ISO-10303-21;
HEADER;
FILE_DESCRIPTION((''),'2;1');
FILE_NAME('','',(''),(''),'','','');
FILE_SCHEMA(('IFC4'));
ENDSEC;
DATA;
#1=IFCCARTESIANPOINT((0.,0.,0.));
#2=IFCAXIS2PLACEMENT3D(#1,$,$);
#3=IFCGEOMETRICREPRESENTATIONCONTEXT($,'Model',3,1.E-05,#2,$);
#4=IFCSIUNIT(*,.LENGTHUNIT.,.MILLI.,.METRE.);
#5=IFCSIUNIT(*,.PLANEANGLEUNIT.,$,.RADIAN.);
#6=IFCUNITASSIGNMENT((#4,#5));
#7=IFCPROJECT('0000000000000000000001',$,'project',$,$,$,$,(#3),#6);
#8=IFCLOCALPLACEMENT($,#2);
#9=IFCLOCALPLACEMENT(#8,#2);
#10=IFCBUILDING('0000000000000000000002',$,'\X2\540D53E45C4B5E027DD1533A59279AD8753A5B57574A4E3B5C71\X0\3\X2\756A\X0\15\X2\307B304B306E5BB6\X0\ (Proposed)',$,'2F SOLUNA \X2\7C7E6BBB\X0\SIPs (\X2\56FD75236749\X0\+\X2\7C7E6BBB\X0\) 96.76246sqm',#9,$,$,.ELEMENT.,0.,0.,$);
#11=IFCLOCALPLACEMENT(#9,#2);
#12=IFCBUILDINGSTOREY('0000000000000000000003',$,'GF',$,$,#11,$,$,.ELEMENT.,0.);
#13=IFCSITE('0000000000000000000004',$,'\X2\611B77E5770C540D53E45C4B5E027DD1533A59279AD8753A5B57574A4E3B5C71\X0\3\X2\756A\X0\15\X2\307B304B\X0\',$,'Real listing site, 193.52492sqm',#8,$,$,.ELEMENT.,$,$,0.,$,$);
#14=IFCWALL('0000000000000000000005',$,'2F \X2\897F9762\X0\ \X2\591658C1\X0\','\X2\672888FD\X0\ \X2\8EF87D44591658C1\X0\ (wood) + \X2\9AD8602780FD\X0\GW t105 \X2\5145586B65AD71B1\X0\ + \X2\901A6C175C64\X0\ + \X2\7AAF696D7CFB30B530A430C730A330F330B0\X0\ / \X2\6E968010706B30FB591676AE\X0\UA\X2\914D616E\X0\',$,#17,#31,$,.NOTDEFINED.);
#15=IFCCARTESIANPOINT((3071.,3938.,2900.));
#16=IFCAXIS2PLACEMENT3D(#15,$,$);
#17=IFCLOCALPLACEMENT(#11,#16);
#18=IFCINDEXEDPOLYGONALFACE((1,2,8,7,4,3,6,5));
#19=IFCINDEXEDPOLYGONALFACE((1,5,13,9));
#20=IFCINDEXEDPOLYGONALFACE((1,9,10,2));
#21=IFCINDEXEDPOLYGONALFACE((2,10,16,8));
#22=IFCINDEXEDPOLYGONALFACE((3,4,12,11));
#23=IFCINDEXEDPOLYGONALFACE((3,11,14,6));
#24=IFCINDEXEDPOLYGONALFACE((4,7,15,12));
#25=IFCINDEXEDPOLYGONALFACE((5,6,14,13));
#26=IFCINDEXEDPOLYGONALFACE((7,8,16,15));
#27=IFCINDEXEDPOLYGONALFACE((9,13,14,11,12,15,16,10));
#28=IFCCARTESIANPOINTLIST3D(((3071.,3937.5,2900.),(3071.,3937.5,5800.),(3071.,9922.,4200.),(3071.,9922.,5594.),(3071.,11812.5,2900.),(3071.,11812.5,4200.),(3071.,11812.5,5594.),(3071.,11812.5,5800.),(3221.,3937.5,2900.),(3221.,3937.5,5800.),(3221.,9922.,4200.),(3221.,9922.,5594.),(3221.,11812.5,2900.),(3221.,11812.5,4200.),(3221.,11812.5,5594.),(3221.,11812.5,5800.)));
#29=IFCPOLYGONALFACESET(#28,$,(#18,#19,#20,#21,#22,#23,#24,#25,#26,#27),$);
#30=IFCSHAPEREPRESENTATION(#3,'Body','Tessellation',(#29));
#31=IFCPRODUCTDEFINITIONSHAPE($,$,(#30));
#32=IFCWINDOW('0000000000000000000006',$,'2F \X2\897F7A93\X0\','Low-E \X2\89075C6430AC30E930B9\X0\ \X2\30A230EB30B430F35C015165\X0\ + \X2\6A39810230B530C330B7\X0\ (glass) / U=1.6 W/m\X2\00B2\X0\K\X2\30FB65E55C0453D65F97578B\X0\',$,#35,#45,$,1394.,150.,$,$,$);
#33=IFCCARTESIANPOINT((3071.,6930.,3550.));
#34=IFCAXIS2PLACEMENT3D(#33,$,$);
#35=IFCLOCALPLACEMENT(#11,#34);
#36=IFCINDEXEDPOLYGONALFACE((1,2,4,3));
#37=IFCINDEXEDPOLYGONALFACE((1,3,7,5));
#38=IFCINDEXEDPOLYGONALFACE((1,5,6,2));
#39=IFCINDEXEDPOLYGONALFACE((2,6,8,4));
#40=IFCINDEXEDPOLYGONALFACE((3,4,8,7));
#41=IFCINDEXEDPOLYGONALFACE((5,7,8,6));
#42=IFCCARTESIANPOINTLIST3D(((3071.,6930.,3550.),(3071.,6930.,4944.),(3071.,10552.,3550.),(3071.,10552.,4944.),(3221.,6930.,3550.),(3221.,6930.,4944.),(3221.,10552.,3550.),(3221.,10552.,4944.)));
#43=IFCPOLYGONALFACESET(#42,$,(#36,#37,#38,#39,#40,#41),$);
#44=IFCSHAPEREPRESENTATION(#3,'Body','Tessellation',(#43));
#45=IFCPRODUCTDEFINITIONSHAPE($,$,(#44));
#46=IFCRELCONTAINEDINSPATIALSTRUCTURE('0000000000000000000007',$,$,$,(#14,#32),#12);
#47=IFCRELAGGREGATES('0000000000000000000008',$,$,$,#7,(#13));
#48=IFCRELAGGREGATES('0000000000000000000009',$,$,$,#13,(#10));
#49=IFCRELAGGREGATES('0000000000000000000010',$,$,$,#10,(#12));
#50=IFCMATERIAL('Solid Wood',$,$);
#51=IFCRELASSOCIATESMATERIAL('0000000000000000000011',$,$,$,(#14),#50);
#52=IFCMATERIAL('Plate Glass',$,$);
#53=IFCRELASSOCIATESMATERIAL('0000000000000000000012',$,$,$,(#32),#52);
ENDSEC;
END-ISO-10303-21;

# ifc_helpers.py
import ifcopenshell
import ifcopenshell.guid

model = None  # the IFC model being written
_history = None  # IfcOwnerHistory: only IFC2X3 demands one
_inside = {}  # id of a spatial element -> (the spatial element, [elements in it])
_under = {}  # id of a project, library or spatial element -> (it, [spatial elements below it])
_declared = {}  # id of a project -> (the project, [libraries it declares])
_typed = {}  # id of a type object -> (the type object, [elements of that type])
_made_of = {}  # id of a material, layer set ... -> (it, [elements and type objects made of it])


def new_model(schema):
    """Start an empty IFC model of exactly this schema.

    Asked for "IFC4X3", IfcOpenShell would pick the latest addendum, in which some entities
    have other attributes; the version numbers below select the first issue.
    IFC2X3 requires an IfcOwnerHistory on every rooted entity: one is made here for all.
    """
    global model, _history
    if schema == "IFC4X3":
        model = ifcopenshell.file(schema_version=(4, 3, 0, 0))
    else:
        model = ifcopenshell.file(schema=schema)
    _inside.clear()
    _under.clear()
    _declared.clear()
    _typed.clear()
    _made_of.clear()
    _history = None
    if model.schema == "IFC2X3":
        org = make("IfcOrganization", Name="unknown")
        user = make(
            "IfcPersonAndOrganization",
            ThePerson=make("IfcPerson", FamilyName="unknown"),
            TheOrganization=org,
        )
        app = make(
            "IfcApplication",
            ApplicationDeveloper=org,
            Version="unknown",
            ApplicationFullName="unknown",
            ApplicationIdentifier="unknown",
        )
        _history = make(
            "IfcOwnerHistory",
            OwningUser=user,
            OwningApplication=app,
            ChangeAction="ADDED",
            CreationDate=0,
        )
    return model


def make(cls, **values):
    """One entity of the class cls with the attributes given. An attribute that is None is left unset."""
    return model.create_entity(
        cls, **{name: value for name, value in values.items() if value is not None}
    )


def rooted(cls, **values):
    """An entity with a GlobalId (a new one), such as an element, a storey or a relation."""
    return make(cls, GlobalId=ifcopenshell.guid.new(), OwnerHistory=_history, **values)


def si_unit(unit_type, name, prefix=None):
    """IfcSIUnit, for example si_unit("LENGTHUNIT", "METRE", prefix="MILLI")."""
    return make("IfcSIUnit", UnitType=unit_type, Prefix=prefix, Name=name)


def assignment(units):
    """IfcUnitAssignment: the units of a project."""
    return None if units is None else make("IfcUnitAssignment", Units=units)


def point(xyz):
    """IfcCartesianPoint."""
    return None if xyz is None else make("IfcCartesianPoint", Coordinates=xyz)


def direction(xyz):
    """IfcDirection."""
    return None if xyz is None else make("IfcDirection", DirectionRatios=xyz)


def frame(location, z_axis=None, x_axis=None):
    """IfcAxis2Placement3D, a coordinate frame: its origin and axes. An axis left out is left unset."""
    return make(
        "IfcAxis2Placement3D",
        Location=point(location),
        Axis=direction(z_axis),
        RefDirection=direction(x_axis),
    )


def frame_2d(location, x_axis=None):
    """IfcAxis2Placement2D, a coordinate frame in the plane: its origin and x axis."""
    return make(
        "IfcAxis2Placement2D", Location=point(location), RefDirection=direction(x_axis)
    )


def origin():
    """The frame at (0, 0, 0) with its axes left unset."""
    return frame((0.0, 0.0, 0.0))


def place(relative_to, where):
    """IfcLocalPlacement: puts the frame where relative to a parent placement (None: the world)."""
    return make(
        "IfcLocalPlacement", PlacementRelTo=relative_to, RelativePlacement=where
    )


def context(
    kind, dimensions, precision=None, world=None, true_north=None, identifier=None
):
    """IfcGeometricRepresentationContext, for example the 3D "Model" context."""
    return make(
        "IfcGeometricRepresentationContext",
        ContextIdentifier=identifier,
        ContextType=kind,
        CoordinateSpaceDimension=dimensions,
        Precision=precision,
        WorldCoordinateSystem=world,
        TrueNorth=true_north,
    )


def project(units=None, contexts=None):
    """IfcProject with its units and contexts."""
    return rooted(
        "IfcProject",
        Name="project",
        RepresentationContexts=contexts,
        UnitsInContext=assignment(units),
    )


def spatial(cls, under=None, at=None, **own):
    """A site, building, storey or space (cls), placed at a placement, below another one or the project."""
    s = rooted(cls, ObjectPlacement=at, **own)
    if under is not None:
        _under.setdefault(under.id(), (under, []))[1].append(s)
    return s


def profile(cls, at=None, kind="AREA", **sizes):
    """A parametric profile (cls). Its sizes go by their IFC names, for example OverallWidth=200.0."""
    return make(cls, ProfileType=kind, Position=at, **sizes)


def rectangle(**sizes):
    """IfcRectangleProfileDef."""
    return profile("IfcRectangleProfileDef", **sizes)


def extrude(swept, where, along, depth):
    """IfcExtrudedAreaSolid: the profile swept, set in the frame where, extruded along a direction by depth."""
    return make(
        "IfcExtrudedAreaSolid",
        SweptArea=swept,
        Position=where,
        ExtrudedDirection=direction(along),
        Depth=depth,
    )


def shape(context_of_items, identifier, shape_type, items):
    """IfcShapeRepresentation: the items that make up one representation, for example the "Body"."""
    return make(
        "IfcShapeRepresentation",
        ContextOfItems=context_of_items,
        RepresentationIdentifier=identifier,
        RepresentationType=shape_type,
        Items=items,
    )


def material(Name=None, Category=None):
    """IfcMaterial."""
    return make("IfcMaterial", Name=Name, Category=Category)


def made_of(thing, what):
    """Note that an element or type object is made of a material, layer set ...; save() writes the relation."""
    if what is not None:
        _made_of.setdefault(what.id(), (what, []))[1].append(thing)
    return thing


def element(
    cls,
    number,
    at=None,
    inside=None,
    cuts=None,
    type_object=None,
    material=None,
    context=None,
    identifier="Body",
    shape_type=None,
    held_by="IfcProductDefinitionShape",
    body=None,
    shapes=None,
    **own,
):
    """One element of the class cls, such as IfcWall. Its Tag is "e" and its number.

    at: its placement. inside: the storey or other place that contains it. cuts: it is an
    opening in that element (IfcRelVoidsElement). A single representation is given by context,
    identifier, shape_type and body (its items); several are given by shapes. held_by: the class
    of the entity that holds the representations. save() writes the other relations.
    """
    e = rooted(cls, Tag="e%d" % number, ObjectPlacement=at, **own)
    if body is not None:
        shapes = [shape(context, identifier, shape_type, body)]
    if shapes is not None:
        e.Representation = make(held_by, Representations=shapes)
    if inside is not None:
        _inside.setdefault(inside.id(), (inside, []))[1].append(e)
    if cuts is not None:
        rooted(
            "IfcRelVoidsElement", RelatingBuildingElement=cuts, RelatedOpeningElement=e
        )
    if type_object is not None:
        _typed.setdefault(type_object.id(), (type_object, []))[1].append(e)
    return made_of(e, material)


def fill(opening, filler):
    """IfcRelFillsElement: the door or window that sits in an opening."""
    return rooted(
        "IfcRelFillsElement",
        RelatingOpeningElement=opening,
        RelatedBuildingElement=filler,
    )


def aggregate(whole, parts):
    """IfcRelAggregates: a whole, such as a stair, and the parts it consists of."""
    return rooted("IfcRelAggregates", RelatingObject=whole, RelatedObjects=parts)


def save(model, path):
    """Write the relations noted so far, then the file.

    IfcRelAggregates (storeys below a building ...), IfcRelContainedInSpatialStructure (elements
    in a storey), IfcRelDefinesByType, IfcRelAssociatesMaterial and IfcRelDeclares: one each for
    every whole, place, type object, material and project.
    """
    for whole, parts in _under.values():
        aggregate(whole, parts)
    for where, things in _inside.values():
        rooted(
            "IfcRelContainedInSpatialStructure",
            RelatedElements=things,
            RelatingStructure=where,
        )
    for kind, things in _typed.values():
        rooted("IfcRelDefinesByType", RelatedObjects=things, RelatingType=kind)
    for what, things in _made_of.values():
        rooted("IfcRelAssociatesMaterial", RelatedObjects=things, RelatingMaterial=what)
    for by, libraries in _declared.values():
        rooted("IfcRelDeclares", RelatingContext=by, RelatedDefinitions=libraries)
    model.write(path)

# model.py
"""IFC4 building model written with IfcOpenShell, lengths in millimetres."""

from ifc_helpers import new_model, si_unit, frame, frame_2d, origin, place, context, project, spatial, rectangle, extrude, material, element, fill, save


model = new_model("IFC4")

# Units and contexts
model_context = context("Model", 3, precision=1e-05, world=origin())
ifc_project = project(units=[si_unit("LENGTHUNIT", "METRE", prefix="MILLI"), si_unit("PLANEANGLEUNIT", "RADIAN")], contexts=[model_context])

# Site, building, storey
site_placement = place(None, origin())
site = spatial("IfcSite", under=ifc_project, at=site_placement, Name="愛知県名古屋市緑区大高町字坊主山3番15ほか", ObjectType="Real listing site, 193.52492sqm", CompositionType="ELEMENT", RefElevation=0.0)
building_placement = place(site_placement, origin())
building = spatial("IfcBuilding", under=site, at=building_placement, Name="名古屋市緑区大高町字坊主山3番15ほかの家 (Proposed)", ObjectType="2F SOLUNA 籾殻SIPs (国産杉+籾殻) 96.76246sqm", CompositionType="ELEMENT", ElevationOfRefHeight=0.0, ElevationOfTerrain=0.0)
storey_placement = place(building_placement, origin())
storey = spatial("IfcBuildingStorey", under=building, at=storey_placement, Name="GF", CompositionType="ELEMENT", Elevation=0.0)

# Shared definitions
ifc_material_1 = material(Name="Solid Wood")

# Shared definitions
ifc_material_2 = material(Name="Plate Glass")

# Wall, opening, window
wall_1_placement = place(storey_placement, frame((3071.0, 3938.0, 2900.0)))
wall_1 = element("IfcWall", 1, at=wall_1_placement, inside=storey, material=ifc_material_1, Name="2F 西面 外壁", Description="木製 軸組外壁 (wood) + 高性能GW t105 充填断熱 + 通気層 + 窯業系サイディング / 準耐火・外皮UA配慮", PredefinedType="NOTDEFINED", context=model_context, shape_type="SweptSolid", body=[
    extrude(rectangle(XDim=150.0, YDim=7875.0, at=frame_2d((75.0, 3937.0))), frame((3071.0, 3938.0, 2900.0)), (0.0, 0.0, 1.0), 2900.0),
])
opening_1_placement = place(storey_placement, frame((3071.0, 6930.0, 3550.0)))
opening_1 = element("IfcOpeningElement", 2, at=opening_1_placement, cuts=wall_1, PredefinedType="NOTDEFINED", context=model_context, shape_type="SweptSolid", body=[
    extrude(rectangle(XDim=150.0, YDim=3622.0, at=frame_2d((75.0, 1811.0))), frame((3071.0, 6930.0, 3550.0)), (0.0, 0.0, 1.0), 1394.0),
])
window_1_placement = place(storey_placement, frame((3071.0, 6930.0, 3550.0)))
window_1 = element("IfcWindow", 3, at=window_1_placement, inside=storey, material=ifc_material_2, Name="2F 西窓", Description="Low-E 複層ガラス アルゴン封入 + 樹脂サッシ (glass) / U=1.6 W/m²K・日射取得型", OverallHeight=1394.0, OverallWidth=150.0, context=model_context, shape_type="SweptSolid", body=[
    extrude(rectangle(XDim=150.0, YDim=3622.0, at=frame_2d((75.0, 1811.0))), frame((3071.0, 6930.0, 3550.0)), (0.0, 0.0, 1.0), 1394.0),
])
fill(opening_1, window_1)

save(model, "model.ifc")
